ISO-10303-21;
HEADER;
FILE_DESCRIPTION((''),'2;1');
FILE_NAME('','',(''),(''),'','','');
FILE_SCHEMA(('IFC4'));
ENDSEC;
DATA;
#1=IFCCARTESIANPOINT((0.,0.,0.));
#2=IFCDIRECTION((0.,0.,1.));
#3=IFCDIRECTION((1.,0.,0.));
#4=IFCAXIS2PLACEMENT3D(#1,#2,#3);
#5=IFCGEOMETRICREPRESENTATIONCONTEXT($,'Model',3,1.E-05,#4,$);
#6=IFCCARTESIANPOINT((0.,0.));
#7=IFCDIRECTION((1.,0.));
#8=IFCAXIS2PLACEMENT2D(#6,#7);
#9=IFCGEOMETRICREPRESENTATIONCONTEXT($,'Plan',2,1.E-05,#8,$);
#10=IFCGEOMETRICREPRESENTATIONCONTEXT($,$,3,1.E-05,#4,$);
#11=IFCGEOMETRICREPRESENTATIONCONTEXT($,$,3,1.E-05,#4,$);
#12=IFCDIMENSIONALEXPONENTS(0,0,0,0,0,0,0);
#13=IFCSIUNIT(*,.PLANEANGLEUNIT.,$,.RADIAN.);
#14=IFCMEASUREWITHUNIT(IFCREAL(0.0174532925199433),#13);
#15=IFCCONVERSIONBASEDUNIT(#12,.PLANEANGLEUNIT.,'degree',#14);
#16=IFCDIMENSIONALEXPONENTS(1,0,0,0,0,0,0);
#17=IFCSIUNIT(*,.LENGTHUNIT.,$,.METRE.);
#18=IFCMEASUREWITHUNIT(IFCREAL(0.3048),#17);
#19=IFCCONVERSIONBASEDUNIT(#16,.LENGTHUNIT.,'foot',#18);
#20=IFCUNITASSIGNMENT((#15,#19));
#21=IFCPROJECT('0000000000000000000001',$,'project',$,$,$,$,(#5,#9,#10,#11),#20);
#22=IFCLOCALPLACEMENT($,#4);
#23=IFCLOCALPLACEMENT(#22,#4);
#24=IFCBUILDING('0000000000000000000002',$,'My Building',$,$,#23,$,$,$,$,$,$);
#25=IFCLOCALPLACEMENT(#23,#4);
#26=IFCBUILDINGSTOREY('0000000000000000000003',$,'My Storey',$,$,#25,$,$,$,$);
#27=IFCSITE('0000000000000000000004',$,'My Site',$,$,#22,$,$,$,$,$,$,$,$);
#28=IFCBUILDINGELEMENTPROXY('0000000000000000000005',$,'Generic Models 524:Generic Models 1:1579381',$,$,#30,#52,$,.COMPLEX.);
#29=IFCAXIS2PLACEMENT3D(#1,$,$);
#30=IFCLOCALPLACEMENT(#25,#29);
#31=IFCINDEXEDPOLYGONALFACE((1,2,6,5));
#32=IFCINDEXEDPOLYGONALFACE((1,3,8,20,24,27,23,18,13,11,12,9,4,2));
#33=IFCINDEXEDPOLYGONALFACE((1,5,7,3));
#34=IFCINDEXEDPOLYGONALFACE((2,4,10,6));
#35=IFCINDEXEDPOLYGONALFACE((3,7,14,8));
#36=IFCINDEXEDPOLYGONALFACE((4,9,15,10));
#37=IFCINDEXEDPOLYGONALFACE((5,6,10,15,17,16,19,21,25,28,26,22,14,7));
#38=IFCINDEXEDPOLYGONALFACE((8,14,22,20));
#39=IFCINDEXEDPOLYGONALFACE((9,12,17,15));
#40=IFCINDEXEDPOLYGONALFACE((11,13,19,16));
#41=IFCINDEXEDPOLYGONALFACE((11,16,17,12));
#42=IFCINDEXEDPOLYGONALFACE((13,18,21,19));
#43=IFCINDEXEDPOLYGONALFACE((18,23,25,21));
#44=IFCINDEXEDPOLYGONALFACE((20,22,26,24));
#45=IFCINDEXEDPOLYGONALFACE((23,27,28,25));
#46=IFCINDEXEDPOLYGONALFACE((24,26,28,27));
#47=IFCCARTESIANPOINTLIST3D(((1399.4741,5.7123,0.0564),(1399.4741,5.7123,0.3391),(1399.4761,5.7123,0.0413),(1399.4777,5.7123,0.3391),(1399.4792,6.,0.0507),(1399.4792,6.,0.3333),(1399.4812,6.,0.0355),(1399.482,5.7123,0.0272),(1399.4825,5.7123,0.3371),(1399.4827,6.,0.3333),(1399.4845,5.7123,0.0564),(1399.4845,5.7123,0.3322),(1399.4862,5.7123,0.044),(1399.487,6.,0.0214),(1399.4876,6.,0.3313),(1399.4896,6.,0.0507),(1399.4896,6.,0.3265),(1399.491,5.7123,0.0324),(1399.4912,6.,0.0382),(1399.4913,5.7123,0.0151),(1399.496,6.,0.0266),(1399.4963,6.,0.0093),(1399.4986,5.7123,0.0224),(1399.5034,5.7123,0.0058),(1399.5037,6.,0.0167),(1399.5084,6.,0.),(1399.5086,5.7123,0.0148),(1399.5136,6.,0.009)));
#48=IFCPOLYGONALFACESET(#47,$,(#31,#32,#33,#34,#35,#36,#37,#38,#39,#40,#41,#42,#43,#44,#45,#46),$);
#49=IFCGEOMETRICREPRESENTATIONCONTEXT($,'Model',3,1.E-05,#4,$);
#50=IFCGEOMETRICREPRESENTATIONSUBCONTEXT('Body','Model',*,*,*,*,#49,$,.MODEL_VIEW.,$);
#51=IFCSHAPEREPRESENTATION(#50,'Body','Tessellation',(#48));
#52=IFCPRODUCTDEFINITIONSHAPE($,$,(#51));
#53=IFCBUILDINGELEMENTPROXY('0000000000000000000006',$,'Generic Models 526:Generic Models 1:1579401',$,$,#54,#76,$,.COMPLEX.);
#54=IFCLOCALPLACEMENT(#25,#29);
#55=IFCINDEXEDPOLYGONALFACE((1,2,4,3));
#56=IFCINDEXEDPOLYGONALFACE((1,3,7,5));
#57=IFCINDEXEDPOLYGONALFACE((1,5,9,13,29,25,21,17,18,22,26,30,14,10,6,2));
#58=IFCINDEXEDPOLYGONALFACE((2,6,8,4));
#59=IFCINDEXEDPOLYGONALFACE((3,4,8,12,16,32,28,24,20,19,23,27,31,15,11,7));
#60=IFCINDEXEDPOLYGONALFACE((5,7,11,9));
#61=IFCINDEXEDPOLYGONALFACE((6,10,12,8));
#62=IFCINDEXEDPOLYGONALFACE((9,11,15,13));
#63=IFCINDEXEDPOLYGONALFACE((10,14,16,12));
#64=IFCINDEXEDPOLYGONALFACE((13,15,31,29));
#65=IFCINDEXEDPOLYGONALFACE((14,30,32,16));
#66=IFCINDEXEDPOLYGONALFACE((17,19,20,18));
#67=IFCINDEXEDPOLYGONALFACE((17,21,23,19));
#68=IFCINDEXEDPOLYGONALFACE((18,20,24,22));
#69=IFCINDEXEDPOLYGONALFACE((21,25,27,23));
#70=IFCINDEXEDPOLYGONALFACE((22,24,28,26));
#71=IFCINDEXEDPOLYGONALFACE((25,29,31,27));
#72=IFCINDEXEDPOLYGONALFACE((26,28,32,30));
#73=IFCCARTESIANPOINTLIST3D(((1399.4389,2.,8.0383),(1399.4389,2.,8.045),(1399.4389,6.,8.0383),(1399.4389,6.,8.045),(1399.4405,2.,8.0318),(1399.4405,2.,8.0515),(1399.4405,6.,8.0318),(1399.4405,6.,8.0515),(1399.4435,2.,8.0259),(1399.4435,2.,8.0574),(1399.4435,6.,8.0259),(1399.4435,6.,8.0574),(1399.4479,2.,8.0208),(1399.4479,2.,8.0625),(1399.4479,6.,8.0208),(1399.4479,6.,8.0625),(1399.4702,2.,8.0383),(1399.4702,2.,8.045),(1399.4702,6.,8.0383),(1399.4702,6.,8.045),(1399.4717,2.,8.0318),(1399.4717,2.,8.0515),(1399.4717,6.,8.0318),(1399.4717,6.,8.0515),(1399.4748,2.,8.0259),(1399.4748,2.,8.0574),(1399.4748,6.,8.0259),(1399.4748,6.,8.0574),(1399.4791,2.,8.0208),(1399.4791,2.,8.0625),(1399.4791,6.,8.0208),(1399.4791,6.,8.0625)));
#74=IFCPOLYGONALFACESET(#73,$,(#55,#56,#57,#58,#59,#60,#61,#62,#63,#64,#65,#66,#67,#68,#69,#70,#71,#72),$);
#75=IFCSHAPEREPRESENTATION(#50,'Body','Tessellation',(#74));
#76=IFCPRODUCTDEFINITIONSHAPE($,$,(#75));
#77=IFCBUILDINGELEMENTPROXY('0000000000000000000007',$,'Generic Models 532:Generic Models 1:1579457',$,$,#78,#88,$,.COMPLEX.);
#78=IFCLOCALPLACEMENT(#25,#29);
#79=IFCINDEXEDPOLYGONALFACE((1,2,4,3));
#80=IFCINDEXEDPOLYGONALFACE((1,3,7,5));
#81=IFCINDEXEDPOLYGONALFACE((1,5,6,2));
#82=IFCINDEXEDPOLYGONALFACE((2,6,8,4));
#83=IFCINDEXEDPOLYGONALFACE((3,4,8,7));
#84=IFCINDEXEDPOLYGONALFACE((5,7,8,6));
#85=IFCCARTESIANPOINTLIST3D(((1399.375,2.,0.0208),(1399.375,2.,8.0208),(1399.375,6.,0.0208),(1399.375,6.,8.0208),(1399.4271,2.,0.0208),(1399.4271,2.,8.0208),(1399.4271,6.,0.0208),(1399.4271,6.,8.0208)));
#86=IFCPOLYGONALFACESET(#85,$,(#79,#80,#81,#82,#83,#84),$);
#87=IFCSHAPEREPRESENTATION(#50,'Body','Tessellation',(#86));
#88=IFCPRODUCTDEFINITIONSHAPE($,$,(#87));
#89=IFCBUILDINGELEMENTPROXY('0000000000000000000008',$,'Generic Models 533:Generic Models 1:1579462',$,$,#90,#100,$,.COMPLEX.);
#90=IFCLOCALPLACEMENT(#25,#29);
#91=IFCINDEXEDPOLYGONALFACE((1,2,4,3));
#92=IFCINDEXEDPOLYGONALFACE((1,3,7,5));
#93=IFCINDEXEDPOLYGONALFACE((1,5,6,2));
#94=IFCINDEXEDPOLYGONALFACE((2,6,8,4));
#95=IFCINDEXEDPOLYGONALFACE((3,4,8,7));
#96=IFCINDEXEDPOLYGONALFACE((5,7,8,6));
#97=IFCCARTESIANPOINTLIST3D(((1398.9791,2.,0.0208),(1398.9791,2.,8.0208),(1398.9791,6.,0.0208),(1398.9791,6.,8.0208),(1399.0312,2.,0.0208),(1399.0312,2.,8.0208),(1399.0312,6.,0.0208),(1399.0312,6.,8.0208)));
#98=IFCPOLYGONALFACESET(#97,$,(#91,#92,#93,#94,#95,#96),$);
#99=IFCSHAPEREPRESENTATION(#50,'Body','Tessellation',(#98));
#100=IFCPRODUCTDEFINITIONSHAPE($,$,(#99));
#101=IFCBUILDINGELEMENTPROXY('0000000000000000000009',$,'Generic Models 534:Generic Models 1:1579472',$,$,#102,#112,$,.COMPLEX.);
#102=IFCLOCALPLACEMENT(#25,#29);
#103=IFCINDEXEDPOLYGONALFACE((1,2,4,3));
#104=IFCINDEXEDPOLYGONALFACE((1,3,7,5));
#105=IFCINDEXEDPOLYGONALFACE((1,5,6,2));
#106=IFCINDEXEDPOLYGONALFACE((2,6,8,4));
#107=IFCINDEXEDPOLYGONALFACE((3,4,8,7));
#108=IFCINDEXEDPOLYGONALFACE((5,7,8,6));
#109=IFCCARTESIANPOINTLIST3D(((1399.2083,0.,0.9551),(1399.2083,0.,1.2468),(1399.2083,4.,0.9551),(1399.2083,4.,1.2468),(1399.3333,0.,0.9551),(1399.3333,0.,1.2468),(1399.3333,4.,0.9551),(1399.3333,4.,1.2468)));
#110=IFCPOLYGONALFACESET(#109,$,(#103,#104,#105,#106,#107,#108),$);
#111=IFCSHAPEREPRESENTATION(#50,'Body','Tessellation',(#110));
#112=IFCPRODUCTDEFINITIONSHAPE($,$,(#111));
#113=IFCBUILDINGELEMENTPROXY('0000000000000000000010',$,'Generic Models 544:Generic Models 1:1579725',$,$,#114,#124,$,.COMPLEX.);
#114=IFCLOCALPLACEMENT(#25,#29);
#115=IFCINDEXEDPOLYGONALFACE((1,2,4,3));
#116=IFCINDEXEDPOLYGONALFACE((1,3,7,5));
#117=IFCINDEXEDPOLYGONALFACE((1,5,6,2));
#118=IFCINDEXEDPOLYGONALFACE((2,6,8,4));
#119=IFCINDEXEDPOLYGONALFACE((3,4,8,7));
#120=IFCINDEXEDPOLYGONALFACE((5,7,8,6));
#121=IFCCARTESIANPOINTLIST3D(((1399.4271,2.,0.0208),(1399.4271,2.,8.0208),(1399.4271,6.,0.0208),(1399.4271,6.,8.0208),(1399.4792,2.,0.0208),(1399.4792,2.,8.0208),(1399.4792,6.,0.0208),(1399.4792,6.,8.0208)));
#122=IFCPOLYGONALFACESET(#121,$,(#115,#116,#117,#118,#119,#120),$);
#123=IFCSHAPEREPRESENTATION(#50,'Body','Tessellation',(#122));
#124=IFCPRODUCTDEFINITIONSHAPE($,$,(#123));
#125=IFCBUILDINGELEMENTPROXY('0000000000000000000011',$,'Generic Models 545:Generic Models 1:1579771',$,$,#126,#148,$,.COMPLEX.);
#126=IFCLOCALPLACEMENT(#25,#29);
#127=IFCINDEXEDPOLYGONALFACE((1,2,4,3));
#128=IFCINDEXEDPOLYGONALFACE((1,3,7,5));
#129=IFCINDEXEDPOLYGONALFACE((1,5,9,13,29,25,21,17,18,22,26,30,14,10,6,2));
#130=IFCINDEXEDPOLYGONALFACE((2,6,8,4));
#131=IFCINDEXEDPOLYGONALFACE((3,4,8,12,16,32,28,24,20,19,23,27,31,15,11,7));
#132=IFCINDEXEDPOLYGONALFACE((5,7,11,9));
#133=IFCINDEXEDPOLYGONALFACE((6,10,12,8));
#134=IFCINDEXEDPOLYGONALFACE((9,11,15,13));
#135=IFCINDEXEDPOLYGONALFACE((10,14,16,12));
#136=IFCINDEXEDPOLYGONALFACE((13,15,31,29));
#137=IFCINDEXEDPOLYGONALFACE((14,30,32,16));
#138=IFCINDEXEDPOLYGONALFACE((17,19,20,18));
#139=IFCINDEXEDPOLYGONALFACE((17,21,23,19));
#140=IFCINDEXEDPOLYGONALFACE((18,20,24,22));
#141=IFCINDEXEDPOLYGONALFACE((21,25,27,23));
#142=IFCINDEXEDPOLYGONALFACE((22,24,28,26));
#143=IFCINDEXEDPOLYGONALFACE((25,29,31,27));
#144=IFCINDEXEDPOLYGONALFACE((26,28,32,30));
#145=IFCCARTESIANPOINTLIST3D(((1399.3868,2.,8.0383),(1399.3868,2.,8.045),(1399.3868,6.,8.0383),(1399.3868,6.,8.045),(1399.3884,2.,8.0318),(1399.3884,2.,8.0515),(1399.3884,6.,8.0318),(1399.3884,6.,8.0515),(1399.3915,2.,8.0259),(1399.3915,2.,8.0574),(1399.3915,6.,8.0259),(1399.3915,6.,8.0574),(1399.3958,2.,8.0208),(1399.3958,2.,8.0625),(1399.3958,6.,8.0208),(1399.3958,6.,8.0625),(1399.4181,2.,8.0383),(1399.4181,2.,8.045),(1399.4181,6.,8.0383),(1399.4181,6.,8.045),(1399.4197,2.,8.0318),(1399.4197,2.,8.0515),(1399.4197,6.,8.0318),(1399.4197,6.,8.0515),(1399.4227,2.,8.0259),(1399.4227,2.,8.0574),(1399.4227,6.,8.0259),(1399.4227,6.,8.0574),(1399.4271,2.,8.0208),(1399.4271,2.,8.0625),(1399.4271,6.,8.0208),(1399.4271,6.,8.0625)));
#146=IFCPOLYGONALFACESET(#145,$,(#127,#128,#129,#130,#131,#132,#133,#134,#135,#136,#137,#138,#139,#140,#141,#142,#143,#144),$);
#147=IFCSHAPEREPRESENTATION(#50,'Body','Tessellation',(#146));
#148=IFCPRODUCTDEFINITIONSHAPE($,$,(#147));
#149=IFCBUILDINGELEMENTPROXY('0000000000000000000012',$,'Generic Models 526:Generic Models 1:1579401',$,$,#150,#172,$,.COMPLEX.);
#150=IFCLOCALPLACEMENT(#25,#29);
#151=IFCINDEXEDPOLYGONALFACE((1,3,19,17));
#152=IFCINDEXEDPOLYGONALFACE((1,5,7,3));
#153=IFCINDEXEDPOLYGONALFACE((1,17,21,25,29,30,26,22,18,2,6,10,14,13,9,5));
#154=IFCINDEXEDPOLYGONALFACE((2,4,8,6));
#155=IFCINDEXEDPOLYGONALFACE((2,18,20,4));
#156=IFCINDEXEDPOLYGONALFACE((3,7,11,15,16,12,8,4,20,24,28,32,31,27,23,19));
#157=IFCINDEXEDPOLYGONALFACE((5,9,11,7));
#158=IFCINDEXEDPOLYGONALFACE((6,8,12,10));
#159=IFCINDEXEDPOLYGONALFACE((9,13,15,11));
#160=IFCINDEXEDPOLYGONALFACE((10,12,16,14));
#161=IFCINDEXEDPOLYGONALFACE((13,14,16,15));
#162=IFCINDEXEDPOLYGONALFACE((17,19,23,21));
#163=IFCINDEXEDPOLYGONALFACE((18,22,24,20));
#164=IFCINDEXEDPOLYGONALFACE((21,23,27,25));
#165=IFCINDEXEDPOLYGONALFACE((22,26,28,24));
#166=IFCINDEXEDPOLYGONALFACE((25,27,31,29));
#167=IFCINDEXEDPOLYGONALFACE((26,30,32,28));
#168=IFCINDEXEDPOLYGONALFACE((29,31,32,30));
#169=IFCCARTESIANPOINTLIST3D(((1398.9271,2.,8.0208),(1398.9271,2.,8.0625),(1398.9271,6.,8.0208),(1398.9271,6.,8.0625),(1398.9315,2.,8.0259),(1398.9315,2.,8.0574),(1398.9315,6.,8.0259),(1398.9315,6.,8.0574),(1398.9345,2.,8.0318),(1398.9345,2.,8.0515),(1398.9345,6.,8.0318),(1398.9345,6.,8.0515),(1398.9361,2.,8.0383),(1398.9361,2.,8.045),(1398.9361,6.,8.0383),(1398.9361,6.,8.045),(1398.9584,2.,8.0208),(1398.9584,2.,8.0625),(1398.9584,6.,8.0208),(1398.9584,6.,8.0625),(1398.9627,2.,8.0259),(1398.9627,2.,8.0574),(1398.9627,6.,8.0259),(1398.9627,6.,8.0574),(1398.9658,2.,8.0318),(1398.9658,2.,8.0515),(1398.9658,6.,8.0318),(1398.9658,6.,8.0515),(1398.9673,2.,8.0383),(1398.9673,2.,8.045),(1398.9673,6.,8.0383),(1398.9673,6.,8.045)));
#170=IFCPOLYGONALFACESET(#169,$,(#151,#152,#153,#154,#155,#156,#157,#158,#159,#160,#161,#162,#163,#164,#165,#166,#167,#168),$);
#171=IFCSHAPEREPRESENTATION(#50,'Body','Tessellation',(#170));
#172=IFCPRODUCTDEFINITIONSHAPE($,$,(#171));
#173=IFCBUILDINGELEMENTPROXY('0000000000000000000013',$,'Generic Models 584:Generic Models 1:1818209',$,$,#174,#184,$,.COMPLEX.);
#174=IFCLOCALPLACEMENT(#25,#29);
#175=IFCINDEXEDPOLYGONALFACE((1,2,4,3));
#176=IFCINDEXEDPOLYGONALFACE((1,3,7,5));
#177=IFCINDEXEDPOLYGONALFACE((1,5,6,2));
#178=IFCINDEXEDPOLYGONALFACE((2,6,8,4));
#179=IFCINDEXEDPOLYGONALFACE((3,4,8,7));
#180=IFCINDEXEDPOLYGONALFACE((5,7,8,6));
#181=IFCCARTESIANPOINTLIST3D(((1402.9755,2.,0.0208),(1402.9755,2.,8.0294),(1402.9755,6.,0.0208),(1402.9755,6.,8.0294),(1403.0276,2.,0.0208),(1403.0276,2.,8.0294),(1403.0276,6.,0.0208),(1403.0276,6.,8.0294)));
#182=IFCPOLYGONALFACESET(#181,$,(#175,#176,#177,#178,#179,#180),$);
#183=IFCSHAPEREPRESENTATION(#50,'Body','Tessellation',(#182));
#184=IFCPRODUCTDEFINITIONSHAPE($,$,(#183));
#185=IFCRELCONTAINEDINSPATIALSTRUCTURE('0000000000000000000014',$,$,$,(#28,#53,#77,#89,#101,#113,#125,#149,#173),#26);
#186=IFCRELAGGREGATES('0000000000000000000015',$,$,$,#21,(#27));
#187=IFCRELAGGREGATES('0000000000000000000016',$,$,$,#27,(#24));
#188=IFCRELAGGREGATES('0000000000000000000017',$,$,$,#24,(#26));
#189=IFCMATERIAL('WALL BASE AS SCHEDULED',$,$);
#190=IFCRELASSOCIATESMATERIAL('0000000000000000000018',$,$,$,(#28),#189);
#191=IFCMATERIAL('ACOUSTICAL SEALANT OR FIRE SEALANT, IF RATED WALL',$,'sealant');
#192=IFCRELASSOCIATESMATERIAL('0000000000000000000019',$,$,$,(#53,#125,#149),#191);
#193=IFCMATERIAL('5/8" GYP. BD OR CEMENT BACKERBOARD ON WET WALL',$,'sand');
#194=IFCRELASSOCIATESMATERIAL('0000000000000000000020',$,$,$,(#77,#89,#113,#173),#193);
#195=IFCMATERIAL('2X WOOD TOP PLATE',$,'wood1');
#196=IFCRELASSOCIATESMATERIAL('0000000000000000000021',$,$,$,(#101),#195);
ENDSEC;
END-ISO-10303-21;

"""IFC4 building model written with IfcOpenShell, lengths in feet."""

from ifc_helpers import new_model, entity, si_unit, converted_unit, frame, origin_with_axes, origin_2d_with_axis, place, context, subcontext, project, spatial, polyline, outline, extrude, material, element, save


model = new_model("IFC4")

# Units and contexts
model_context_1 = context("Model", 3, precision=1e-05, world=origin_with_axes())
plan_context = context("Plan", 2, precision=1e-05, world=origin_2d_with_axis())
model_context_2 = context("Model", 3, precision=1e-05, world=origin_with_axes())
context_of_model_1 = context(None, 3, precision=1e-05, world=origin_with_axes())
context_of_model_2 = context(None, 3, precision=1e-05, world=origin_with_axes())
body_context = subcontext(model_context_2, "Body", "Model", "MODEL_VIEW")
ifc_project = project(units=[converted_unit("PLANEANGLEUNIT", "degree", entity("IfcReal", 0.0174532925199433), si_unit("PLANEANGLEUNIT", "RADIAN"), dimensions=[0, 0, 0, 0, 0, 0, 0]), converted_unit("LENGTHUNIT", "foot", entity("IfcReal", 0.3048), si_unit("LENGTHUNIT", "METRE"), dimensions=[1, 0, 0, 0, 0, 0, 0])], contexts=[model_context_1, plan_context, context_of_model_1, context_of_model_2])

# Site, building, storey
site_placement = place(None, origin_with_axes())
site = spatial("IfcSite", under=ifc_project, at=site_placement, Name="My Site")
building_placement = place(site_placement, origin_with_axes())
building = spatial("IfcBuilding", under=site, at=building_placement, Name="My Building")
storey_placement = place(building_placement, origin_with_axes())
storey = spatial("IfcBuildingStorey", under=building, at=storey_placement, Name="My Storey")

# Building element proxies
ifc_material_1 = material(Name="ACOUSTICAL SEALANT OR FIRE SEALANT, IF RATED WALL", Category="sealant")
ifc_material_2 = material(Name="WALL BASE AS SCHEDULED")
proxy_1_placement = place(storey_placement, frame((1399.4792, 6.0, 0.0), z_axis=(0.0, -1.0, 0.0), x_axis=(0.0, 0.0, 1.0)))
element("IfcBuildingElementProxy", 1, at=proxy_1_placement, inside=storey, material=ifc_material_2, Name="Generic Models 524:Generic Models 1:1579381", PredefinedType="COMPLEX", context=body_context, shape_type="SweptSolid", body=[
    extrude(outline(polyline([(0.0865, 0.0), (0.0968, -0.0072), (0.105, -0.0167), (0.1137, -0.0111), (0.1038, 0.0006), (0.0913, 0.0093), (0.0769, 0.0144), (0.0617, 0.0157), (-0.2206, 0.0019), (-0.2205, -0.0017), (-0.2182, -0.0064), (-0.2133, -0.0082), (0.0622, 0.0053), (0.0747, 0.0042), (0.0865, 0.0)])), frame((0.113, -0.0126, 0.0), z_axis=(0.0, 0.0, -1.0), x_axis=(-0.998808, -0.048806, 0.0)), (-0.020832, 0.016543, -0.999646), 0.2878),
])
proxy_2_placement = place(storey_placement, frame((1399.4389, 6.0, 8.0208), z_axis=(0.0, -1.0, 0.0), x_axis=(0.0, 0.0, 1.0)))
element("IfcBuildingElementProxy", 2, at=proxy_2_placement, inside=storey, material=ifc_material_1, Name="Generic Models 526:Generic Models 1:1579401", PredefinedType="COMPLEX", context=body_context, shape_type="SweptSolid", body=[
    extrude(outline(polyline([(0.0294, 0.0), (0.0074, 0.0221), (0.0007, 0.0216), (-0.0057, 0.0196), (-0.0114, 0.0161), (-0.0161, 0.0114), (-0.0196, 0.0057), (-0.0216, -0.0007), (-0.0221, -0.0073), (0.0, -0.0294), (0.0005, -0.0228), (0.0025, -0.0164), (0.006, -0.0107), (0.0107, -0.006), (0.0164, -0.0025), (0.0228, -0.0005), (0.0294, 0.0)])), frame((0.0208, -0.0194, 0.0), z_axis=(0.0, 0.0, -1.0), x_axis=(-0.707667, -0.706546, 0.0)), (0.0, 0.0, -1.0), 4.0),
])
ifc_material_3 = material(Name="5/8\" GYP. BD OR CEMENT BACKERBOARD ON WET WALL", Category="sand")
proxy_3_placement = place(storey_placement, frame((1399.375, 6.0, 0.0208), z_axis=(0.0, -1.0, 0.0), x_axis=(0.0, 0.0, 1.0)))
element("IfcBuildingElementProxy", 3, at=proxy_3_placement, inside=storey, material=ifc_material_3, Name="Generic Models 532:Generic Models 1:1579457", PredefinedType="COMPLEX", context=body_context, shape_type="SweptSolid", body=[
    extrude(outline(polyline([(-4.0, -0.026), (4.0, -0.026), (4.0, 0.026), (-4.0, 0.026), (-4.0, -0.026)])), frame((4.0, -0.026, 0.0), z_axis=(0.0, 0.0, -1.0), x_axis=(1.0, 0.0, 0.0)), (0.0, 0.0, -1.0), 4.0),
])
proxy_4_placement = place(storey_placement, frame((1398.9791, 6.0, 0.0208), z_axis=(0.0, -1.0, 0.0), x_axis=(0.0, 0.0, 1.0)))
element("IfcBuildingElementProxy", 4, at=proxy_4_placement, inside=storey, material=ifc_material_3, Name="Generic Models 533:Generic Models 1:1579462", PredefinedType="COMPLEX", context=body_context, shape_type="SweptSolid", body=[
    extrude(outline(polyline([(-0.026, -4.0), (0.026, -4.0), (0.026, 4.0), (-0.026, 4.0), (-0.026, -4.0)])), frame((4.0, -0.026, 0.0), z_axis=(0.0, 0.0, -1.0), x_axis=(0.0, -1.0, 0.0)), (0.0, 0.0, -1.0), 4.0),
])
ifc_material_4 = material(Name="2X WOOD TOP PLATE", Category="wood1")
proxy_5_placement = place(storey_placement, frame((1399.2083, 4.0, 0.9551), z_axis=(0.0, -1.0, 0.0), x_axis=(0.0, 0.0, 1.0)))
element("IfcBuildingElementProxy", 5, at=proxy_5_placement, inside=storey, material=ifc_material_4, Name="Generic Models 534:Generic Models 1:1579472", PredefinedType="COMPLEX", context=body_context, shape_type="SweptSolid", body=[
    extrude(outline(polyline([(-0.1458, -0.0625), (0.1458, -0.0625), (0.1458, 0.0625), (-0.1458, 0.0625), (-0.1458, -0.0625)])), frame((0.1458, -0.0625, 0.0), z_axis=(0.0, 0.0, -1.0), x_axis=(1.0, 0.0, 0.0)), (0.0, 0.0, -1.0), 4.0),
])
proxy_6_placement = place(storey_placement, frame((1399.4271, 6.0, 0.0208), z_axis=(0.0, -1.0, 0.0), x_axis=(0.0, 0.0, 1.0)))
element("IfcBuildingElementProxy", 6, at=proxy_6_placement, inside=storey, material=ifc_material_3, Name="Generic Models 544:Generic Models 1:1579725", PredefinedType="COMPLEX", context=body_context, shape_type="SweptSolid", body=[
    extrude(outline(polyline([(-4.0, -0.026), (4.0, -0.026), (4.0, 0.026), (-4.0, 0.026), (-4.0, -0.026)])), frame((4.0, -0.026, 0.0), z_axis=(0.0, 0.0, -1.0), x_axis=(1.0, 0.0, 0.0)), (0.0, 0.0, -1.0), 4.0),
])
proxy_7_placement = place(storey_placement, frame((1399.3868, 6.0, 8.0208), z_axis=(0.0, -1.0, 0.0), x_axis=(0.0, 0.0, 1.0)))
element("IfcBuildingElementProxy", 7, at=proxy_7_placement, inside=storey, material=ifc_material_1, Name="Generic Models 545:Generic Models 1:1579771", PredefinedType="COMPLEX", context=body_context, shape_type="SweptSolid", body=[
    extrude(outline(polyline([(0.0166, 0.0), (0.0115, 0.0043), (0.0076, 0.0097), (0.005, 0.0159), (0.0039, 0.0224), (0.0045, 0.0291), (-0.0207, 0.0106), (-0.0213, 0.004), (-0.0202, -0.0026), (-0.0176, -0.0088), (-0.0137, -0.0142), (-0.0086, -0.0185), (-0.0026, -0.0215), (0.0039, -0.023), (0.0291, -0.0045), (0.0226, -0.003), (0.0166, 0.0)])), frame((0.0208, -0.0194, 0.0), z_axis=(0.0, 0.0, -1.0), x_axis=(0.591192, -0.806531, 0.0)), (0.0, 0.0, -1.0), 4.0),
])
proxy_8_placement = place(storey_placement, frame((1398.9271, 6.0, 8.0208), z_axis=(0.0, -1.0, 0.0), x_axis=(0.0, 0.0, 1.0)))
element("IfcBuildingElementProxy", 8, at=proxy_8_placement, inside=storey, material=ifc_material_1, Name="Generic Models 526:Generic Models 1:1579401", PredefinedType="COMPLEX", context=body_context, shape_type="SweptSolid", body=[
    extrude(outline(polyline([(0.0216, 0.0), (0.0223, 0.0066), (0.001, 0.0294), (0.0002, 0.0228), (-0.002, 0.0165), (-0.0057, 0.0109), (-0.0105, 0.0064), (-0.0163, 0.0031), (-0.0228, 0.0012), (-0.0294, 0.0009), (-0.008, -0.0219), (-0.0014, -0.0216), (0.005, -0.0197), (0.0108, -0.0164), (0.0157, -0.0119), (0.0194, -0.0063), (0.0216, 0.0)])), frame((0.0208, -0.0208, 0.0), z_axis=(0.0, 0.0, -1.0), x_axis=(-0.729168, -0.684334, 0.0)), (0.0, 0.0, -1.0), 4.0),
])
proxy_9_placement = place(storey_placement, frame((1402.9755, 6.0, 0.0208), z_axis=(0.0, -1.0, 0.0), x_axis=(0.0, 0.0, 1.0)))
element("IfcBuildingElementProxy", 9, at=proxy_9_placement, inside=storey, material=ifc_material_3, Name="Generic Models 584:Generic Models 1:1818209", PredefinedType="COMPLEX", context=body_context, shape_type="SweptSolid", body=[
    extrude(outline(polyline([(-0.026, -4.0043), (0.026, -4.0043), (0.026, 4.0043), (-0.026, 4.0043), (-0.026, -4.0043)])), frame((4.0043, -0.026, 0.0), z_axis=(0.0, 0.0, -1.0), x_axis=(0.0, 1.0, 0.0)), (0.0, 0.0, -1.0), 4.0),
])

save(model, "model.ifc")
